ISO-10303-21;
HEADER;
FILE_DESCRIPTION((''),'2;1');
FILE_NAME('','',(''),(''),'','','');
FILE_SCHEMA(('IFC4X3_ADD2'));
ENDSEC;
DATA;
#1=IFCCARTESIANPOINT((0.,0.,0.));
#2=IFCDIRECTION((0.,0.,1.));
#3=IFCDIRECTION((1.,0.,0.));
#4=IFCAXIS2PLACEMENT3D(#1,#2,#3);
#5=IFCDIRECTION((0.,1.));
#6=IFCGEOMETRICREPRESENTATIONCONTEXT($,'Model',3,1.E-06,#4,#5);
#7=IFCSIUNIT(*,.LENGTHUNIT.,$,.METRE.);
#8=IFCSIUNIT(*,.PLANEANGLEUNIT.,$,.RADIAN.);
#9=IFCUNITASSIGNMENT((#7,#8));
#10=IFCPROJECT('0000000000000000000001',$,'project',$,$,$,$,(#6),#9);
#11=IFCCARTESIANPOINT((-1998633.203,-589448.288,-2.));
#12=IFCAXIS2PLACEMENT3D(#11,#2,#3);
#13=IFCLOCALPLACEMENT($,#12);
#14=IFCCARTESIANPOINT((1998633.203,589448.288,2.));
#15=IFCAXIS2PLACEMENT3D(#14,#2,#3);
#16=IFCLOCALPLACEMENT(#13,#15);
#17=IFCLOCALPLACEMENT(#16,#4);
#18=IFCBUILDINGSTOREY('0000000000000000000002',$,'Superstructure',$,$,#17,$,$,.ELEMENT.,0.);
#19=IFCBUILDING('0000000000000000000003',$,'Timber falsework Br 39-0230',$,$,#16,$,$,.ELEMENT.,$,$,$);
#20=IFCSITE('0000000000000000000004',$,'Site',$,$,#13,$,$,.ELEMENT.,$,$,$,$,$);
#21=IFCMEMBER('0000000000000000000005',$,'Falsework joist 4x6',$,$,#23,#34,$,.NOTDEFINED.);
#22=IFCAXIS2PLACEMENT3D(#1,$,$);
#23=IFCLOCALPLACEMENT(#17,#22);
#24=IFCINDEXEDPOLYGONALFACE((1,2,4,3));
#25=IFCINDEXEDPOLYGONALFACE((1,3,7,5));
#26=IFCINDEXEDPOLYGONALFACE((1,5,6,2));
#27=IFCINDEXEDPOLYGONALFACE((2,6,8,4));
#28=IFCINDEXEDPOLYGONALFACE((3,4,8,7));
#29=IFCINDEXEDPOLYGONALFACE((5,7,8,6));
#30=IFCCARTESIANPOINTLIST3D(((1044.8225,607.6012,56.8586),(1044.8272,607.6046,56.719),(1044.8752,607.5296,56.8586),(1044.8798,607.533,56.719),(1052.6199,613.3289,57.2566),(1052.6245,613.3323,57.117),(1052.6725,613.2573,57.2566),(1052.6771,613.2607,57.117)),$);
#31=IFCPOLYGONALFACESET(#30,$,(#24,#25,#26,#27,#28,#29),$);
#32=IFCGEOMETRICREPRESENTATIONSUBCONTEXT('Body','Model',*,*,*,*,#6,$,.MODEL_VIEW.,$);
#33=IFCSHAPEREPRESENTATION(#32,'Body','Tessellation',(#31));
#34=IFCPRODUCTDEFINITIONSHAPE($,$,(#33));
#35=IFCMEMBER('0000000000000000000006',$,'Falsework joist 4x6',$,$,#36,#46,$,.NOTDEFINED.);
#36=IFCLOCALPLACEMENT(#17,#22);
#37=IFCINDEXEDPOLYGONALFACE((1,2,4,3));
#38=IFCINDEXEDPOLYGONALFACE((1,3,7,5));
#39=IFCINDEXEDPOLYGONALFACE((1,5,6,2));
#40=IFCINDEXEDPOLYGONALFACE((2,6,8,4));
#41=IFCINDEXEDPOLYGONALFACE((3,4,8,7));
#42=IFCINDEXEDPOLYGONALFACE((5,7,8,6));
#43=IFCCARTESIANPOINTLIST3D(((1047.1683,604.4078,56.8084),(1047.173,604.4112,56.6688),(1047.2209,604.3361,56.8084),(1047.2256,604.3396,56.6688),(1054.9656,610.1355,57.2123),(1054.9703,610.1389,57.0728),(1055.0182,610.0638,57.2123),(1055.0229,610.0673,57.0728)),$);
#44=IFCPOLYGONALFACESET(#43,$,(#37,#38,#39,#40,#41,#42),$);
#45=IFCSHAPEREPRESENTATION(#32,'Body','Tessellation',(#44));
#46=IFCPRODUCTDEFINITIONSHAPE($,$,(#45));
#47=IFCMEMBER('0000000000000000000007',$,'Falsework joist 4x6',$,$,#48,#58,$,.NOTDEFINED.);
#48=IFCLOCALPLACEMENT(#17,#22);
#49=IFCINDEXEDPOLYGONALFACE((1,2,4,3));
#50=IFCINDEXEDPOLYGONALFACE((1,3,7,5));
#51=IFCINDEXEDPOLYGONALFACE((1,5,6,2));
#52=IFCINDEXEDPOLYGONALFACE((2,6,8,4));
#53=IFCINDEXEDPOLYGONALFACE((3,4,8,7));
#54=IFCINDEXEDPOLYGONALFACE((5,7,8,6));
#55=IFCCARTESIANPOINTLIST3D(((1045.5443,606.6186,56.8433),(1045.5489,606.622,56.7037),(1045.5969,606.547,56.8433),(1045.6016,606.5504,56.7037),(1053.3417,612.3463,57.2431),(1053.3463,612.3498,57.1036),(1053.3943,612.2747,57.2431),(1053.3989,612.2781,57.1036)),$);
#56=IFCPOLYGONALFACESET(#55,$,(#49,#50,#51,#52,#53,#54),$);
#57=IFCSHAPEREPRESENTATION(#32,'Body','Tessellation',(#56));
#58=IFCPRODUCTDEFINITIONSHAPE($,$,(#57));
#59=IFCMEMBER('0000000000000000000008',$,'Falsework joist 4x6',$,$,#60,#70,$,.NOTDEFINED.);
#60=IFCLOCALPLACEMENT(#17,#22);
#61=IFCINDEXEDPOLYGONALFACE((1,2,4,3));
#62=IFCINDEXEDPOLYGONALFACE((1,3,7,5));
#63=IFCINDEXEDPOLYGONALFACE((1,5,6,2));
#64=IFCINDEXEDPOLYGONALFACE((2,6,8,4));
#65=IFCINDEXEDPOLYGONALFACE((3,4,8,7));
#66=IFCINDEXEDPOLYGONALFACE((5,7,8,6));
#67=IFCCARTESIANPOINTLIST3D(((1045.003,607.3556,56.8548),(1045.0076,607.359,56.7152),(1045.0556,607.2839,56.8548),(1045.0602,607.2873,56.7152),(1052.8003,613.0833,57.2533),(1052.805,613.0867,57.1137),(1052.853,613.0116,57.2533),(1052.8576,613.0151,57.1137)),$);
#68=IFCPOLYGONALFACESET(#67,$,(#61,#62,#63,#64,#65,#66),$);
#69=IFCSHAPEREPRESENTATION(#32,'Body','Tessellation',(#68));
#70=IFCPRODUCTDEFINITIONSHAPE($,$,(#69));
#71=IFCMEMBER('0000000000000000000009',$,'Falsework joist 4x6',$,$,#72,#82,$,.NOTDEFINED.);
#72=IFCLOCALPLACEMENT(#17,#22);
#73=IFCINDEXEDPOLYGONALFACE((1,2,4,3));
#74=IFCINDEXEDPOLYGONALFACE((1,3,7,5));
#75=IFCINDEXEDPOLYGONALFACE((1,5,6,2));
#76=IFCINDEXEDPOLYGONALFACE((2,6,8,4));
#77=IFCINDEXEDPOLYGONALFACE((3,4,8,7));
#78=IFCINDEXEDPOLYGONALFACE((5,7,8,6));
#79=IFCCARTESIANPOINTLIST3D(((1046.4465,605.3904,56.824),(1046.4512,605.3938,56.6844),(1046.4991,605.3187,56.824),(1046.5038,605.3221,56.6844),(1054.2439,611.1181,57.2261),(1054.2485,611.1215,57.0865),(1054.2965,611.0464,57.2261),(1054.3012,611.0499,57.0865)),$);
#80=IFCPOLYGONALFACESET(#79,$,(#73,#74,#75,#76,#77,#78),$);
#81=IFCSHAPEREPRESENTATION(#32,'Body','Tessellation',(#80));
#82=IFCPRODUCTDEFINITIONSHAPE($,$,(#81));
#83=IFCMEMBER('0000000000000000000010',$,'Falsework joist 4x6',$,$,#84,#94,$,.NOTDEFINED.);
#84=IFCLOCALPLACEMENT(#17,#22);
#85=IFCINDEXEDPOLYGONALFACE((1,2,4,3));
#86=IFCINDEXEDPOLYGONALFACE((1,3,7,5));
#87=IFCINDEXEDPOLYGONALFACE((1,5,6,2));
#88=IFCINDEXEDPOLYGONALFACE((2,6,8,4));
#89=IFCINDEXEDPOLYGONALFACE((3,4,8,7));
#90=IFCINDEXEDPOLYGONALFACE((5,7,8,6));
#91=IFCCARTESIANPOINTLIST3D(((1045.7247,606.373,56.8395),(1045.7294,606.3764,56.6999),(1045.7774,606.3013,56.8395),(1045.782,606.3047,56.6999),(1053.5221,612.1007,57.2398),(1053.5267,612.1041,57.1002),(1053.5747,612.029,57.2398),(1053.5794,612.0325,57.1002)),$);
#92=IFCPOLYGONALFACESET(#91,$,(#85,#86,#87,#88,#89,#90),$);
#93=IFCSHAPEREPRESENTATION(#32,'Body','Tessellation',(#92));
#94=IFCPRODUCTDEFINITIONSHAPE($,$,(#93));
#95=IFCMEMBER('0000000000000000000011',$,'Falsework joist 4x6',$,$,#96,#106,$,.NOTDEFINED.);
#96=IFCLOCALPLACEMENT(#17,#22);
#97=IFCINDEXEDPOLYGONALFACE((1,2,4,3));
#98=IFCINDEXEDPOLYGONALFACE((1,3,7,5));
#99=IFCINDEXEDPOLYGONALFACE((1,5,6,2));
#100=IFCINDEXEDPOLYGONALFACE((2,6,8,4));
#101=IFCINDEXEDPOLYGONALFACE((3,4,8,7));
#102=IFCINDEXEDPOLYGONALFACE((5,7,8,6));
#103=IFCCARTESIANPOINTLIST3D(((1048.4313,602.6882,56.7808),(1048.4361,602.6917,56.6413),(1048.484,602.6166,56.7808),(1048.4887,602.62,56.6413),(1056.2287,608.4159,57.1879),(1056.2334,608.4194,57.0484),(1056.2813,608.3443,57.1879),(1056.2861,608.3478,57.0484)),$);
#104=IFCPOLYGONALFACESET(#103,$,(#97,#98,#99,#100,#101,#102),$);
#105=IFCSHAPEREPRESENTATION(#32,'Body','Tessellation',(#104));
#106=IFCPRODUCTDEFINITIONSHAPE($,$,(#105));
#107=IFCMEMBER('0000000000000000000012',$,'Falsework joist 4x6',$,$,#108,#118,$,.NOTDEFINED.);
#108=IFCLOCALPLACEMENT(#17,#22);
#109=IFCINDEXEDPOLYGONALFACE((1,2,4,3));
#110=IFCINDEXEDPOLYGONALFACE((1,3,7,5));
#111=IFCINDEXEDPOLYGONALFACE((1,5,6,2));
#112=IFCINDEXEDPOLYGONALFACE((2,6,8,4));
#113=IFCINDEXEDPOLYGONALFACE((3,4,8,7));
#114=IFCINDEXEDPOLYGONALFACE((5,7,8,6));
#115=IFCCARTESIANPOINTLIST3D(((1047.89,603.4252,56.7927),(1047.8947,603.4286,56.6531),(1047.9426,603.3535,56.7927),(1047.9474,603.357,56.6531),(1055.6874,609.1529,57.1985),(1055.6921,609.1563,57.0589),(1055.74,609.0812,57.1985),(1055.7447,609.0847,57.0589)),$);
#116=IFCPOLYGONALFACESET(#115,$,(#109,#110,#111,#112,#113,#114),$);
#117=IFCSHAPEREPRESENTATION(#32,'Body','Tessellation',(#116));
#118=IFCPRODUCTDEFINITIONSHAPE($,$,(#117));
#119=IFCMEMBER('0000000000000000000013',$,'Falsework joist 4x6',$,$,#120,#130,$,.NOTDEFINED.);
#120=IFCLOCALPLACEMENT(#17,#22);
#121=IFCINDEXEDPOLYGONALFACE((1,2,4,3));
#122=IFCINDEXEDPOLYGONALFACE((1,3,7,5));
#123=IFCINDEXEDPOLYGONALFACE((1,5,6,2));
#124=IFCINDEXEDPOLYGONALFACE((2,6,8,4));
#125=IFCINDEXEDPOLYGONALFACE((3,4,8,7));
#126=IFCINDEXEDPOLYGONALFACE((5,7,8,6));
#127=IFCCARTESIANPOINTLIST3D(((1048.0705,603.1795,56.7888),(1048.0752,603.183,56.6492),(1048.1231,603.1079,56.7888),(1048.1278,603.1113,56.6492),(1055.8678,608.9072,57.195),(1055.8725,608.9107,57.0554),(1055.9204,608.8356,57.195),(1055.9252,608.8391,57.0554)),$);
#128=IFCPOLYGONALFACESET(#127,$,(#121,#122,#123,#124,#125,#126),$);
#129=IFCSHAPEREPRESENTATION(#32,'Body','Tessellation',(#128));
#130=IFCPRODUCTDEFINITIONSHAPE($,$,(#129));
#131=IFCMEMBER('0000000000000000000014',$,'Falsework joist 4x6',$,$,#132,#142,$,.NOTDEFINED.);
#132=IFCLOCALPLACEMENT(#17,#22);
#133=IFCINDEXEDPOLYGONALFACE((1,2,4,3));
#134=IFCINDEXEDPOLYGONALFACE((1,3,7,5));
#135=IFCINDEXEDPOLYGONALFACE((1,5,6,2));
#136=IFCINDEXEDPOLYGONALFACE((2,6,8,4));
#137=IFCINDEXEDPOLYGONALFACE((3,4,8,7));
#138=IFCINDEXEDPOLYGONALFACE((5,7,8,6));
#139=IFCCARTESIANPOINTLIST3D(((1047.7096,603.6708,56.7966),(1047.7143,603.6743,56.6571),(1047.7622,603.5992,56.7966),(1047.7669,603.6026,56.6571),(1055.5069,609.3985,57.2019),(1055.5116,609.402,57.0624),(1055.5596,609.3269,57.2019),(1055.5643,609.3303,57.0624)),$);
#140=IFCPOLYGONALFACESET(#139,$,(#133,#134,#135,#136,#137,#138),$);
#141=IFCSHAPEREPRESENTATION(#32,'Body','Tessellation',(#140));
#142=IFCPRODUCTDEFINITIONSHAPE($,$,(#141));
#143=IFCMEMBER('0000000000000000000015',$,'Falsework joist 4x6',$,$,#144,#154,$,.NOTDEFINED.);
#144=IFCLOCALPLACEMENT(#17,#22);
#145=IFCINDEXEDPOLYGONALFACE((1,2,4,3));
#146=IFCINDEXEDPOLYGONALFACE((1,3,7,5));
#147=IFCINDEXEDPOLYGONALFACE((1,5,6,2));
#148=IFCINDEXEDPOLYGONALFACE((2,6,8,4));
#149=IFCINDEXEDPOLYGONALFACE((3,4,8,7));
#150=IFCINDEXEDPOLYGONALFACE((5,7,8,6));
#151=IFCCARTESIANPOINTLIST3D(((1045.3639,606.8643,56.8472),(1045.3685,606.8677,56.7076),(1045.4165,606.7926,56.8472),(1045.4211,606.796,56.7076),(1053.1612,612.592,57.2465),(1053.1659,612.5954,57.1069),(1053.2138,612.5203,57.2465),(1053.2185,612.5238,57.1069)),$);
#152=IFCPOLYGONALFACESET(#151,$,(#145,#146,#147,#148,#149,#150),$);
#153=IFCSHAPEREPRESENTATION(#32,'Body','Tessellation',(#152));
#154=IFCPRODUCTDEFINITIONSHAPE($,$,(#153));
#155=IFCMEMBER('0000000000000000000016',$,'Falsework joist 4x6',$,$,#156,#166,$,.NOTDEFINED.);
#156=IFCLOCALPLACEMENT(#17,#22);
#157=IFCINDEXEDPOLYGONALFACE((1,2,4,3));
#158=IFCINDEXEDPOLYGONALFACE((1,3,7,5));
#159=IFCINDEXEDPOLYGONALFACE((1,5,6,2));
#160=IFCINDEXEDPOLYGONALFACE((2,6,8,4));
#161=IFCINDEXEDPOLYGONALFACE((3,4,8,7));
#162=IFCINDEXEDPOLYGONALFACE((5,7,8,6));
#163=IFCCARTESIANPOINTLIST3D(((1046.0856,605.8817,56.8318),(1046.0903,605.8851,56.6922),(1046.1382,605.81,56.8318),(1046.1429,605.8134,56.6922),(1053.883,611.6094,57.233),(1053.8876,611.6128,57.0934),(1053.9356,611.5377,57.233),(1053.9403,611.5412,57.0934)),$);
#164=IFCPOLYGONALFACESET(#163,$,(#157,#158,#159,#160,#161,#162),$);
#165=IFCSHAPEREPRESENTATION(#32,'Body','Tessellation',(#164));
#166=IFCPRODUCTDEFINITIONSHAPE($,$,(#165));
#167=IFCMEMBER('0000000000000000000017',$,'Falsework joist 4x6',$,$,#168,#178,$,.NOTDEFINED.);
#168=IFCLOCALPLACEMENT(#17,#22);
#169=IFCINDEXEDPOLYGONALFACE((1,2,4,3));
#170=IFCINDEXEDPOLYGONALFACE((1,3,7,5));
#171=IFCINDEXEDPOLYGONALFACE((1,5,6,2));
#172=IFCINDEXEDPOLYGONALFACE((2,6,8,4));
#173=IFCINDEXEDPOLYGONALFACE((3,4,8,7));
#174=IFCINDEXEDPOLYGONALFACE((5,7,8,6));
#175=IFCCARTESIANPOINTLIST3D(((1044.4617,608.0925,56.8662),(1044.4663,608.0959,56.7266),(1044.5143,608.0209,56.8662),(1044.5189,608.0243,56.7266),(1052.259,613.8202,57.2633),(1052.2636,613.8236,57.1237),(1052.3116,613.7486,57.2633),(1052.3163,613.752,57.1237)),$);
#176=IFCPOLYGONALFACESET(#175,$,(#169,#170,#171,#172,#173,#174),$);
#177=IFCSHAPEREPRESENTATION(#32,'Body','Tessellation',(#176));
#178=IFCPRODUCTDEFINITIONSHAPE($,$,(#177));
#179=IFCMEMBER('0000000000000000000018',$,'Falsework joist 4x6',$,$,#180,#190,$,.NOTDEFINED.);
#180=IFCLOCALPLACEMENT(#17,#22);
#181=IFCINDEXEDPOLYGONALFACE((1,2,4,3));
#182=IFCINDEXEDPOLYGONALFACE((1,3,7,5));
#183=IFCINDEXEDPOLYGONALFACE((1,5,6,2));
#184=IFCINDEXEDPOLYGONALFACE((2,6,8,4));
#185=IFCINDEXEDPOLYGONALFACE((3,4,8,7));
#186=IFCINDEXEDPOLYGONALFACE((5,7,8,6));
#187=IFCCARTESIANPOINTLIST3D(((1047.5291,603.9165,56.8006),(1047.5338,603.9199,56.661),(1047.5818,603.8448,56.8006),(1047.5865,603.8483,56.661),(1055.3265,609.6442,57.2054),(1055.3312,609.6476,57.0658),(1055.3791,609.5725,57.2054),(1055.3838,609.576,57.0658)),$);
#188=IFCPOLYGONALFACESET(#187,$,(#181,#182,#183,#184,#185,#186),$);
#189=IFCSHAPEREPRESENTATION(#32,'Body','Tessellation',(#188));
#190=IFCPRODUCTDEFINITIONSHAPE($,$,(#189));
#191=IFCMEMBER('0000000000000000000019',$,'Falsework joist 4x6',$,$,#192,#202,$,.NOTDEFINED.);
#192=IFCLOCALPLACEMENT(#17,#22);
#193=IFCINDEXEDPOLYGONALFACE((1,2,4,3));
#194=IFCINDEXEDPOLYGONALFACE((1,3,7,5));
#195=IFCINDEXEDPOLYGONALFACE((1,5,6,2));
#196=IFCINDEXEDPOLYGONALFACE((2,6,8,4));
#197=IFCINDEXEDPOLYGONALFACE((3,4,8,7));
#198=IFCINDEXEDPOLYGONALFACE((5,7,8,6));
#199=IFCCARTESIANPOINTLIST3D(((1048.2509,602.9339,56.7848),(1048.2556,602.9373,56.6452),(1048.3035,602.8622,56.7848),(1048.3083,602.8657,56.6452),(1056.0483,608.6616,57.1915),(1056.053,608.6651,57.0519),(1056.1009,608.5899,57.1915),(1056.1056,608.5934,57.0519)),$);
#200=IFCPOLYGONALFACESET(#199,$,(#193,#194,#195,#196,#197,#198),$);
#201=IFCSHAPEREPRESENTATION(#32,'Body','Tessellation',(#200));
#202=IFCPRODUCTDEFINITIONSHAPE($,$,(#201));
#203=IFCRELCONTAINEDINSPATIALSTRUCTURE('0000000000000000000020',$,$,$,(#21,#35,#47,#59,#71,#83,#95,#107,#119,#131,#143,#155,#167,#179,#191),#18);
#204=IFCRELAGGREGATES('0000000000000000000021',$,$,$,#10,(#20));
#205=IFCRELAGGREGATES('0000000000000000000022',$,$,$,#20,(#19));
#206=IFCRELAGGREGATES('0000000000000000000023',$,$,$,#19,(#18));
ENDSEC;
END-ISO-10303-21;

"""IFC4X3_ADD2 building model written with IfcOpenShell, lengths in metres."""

from ifc_helpers import new_model, si_unit, direction, frame, frame_2d, origin, origin_with_axes, place, context, subcontext, project, spatial, rectangle, extrude, element, save


model = new_model("IFC4X3_ADD2")

# Units and contexts
model_context = context("Model", 3, precision=1e-06, world=origin_with_axes(), true_north=direction((0.0, 1.0)))
body_context = subcontext(model_context, "Body", "Model", "MODEL_VIEW")
ifc_project = project(units=[si_unit("LENGTHUNIT", "METRE"), si_unit("PLANEANGLEUNIT", "RADIAN")], contexts=[model_context])

# Site, building, storey
site_placement = place(None, frame((-1998633.203, -589448.288, -2.0), z_axis=(0.0, 0.0, 1.0), x_axis=(1.0, 0.0, 0.0)))
site = spatial("IfcSite", under=ifc_project, at=site_placement, Name="Site", CompositionType="ELEMENT")
building_placement = place(site_placement, frame((1998633.203, 589448.288, 2.0), z_axis=(0.0, 0.0, 1.0), x_axis=(1.0, 0.0, 0.0)))
building = spatial("IfcBuilding", under=site, at=building_placement, Name="Timber falsework Br 39-0230", CompositionType="ELEMENT")
storey_placement = place(building_placement, origin_with_axes())
storey = spatial("IfcBuildingStorey", under=building, at=storey_placement, Name="Superstructure", CompositionType="ELEMENT", Elevation=0.0)

# Members
member_1_placement = place(storey_placement, frame((1044.8535, 607.5688, 56.719), z_axis=(0.805247, 0.591513, 0.041103), x_axis=(-0.592013, 0.805928, 0.0)))
element("IfcMember", 1, at=member_1_placement, inside=storey, Name="Falsework joist 4x6", PredefinedType="NOTDEFINED", context=body_context, shape_type="SweptSolid", body=[
    extrude(rectangle(XDim=0.0889, YDim=0.1397, at=frame_2d((0.0, 0.0698))), origin(), (0.0, 0.0, 1.0), 9.6832),
])
member_2_placement = place(storey_placement, frame((1047.1993, 604.3754, 56.6688), z_axis=(0.805227, 0.591498, 0.041713), x_axis=(-0.592013, 0.805928, 0.0)))
element("IfcMember", 2, at=member_2_placement, inside=storey, Name="Falsework joist 4x6", PredefinedType="NOTDEFINED", context=body_context, shape_type="SweptSolid", body=[
    extrude(rectangle(XDim=0.0889, YDim=0.1397, at=frame_2d((0.0, 0.0698))), origin(), (0.0, 0.0, 1.0), 9.6834),
])
member_3_placement = place(storey_placement, frame((1045.5753, 606.5862, 56.7037), z_axis=(0.805241, 0.591508, 0.041291), x_axis=(-0.592013, 0.805928, 0.0)))
element("IfcMember", 3, at=member_3_placement, inside=storey, Name="Falsework joist 4x6", PredefinedType="NOTDEFINED", context=body_context, shape_type="SweptSolid", body=[
    extrude(rectangle(XDim=0.0889, YDim=0.1397, at=frame_2d((0.0, 0.0698))), origin(), (0.0, 0.0, 1.0), 9.6833),
])
member_4_placement = place(storey_placement, frame((1045.0339, 607.3231, 56.7152), z_axis=(0.805246, 0.591512, 0.04115), x_axis=(-0.592013, 0.805928, 0.0)))
element("IfcMember", 4, at=member_4_placement, inside=storey, Name="Falsework joist 4x6", PredefinedType="NOTDEFINED", context=body_context, shape_type="SweptSolid", body=[
    extrude(rectangle(XDim=0.0889, YDim=0.1397, at=frame_2d((0.0, 0.0698))), origin(), (0.0, 0.0, 1.0), 9.6832),
])
member_5_placement = place(storey_placement, frame((1046.4775, 605.358, 56.6844), z_axis=(0.805233, 0.591503, 0.041525), x_axis=(-0.592013, 0.805928, 0.0)))
element("IfcMember", 5, at=member_5_placement, inside=storey, Name="Falsework joist 4x6", PredefinedType="NOTDEFINED", context=body_context, shape_type="SweptSolid", body=[
    extrude(rectangle(XDim=0.0889, YDim=0.1397, at=frame_2d((0.0, 0.0698))), origin(), (0.0, 0.0, 1.0), 9.6834),
])
member_6_placement = place(storey_placement, frame((1045.7557, 606.3406, 56.6999), z_axis=(0.805239, 0.591507, 0.041338), x_axis=(-0.592013, 0.805928, 0.0)))
element("IfcMember", 6, at=member_6_placement, inside=storey, Name="Falsework joist 4x6", PredefinedType="NOTDEFINED", context=body_context, shape_type="SweptSolid", body=[
    extrude(rectangle(XDim=0.0889, YDim=0.1397, at=frame_2d((0.0, 0.0698))), origin(), (0.0, 0.0, 1.0), 9.6833),
])
member_7_placement = place(storey_placement, frame((1048.4624, 602.6559, 56.6413), z_axis=(0.805216, 0.59149, 0.042041), x_axis=(-0.592013, 0.805928, 0.0)))
element("IfcMember", 7, at=member_7_placement, inside=storey, Name="Falsework joist 4x6", PredefinedType="NOTDEFINED", context=body_context, shape_type="SweptSolid", body=[
    extrude(rectangle(XDim=0.0889, YDim=0.1397, at=frame_2d((0.0, 0.0698))), origin(), (0.0, 0.0, 1.0), 9.6836),
])
member_8_placement = place(storey_placement, frame((1047.9211, 603.3928, 56.6531), z_axis=(0.805221, 0.591493, 0.041901), x_axis=(-0.592013, 0.805928, 0.0)))
element("IfcMember", 8, at=member_8_placement, inside=storey, Name="Falsework joist 4x6", PredefinedType="NOTDEFINED", context=body_context, shape_type="SweptSolid", body=[
    extrude(rectangle(XDim=0.0889, YDim=0.1397, at=frame_2d((0.0, 0.0698))), origin(), (0.0, 0.0, 1.0), 9.6835),
])
member_9_placement = place(storey_placement, frame((1048.1015, 603.1471, 56.6492), z_axis=(0.805219, 0.591492, 0.041947), x_axis=(-0.592013, 0.805928, 0.0)))
element("IfcMember", 9, at=member_9_placement, inside=storey, Name="Falsework joist 4x6", PredefinedType="NOTDEFINED", context=body_context, shape_type="SweptSolid", body=[
    extrude(rectangle(XDim=0.0889, YDim=0.1397, at=frame_2d((0.0, 0.0698))), origin(), (0.0, 0.0, 1.0), 9.6835),
])
member_10_placement = place(storey_placement, frame((1047.7406, 603.6384, 56.6571), z_axis=(0.805222, 0.591494, 0.041854), x_axis=(-0.592013, 0.805928, 0.0)))
element("IfcMember", 10, at=member_10_placement, inside=storey, Name="Falsework joist 4x6", PredefinedType="NOTDEFINED", context=body_context, shape_type="SweptSolid", body=[
    extrude(rectangle(XDim=0.0889, YDim=0.1397, at=frame_2d((0.0, 0.0698))), origin(), (0.0, 0.0, 1.0), 9.6835),
])
member_11_placement = place(storey_placement, frame((1045.3948, 606.8319, 56.7076), z_axis=(0.805243, 0.591509, 0.041244), x_axis=(-0.592013, 0.805928, 0.0)))
element("IfcMember", 11, at=member_11_placement, inside=storey, Name="Falsework joist 4x6", PredefinedType="NOTDEFINED", context=body_context, shape_type="SweptSolid", body=[
    extrude(rectangle(XDim=0.0889, YDim=0.1397, at=frame_2d((0.0, 0.0698))), origin(), (0.0, 0.0, 1.0), 9.6832),
])
member_12_placement = place(storey_placement, frame((1046.1166, 605.8493, 56.6922), z_axis=(0.805236, 0.591505, 0.041432), x_axis=(-0.592013, 0.805928, 0.0)))
element("IfcMember", 12, at=member_12_placement, inside=storey, Name="Falsework joist 4x6", PredefinedType="NOTDEFINED", context=body_context, shape_type="SweptSolid", body=[
    extrude(rectangle(XDim=0.0889, YDim=0.1397, at=frame_2d((0.0, 0.0698))), origin(), (0.0, 0.0, 1.0), 9.6833),
])
member_13_placement = place(storey_placement, frame((1044.4926, 608.0601, 56.7266), z_axis=(0.80525, 0.591515, 0.04101), x_axis=(-0.592013, 0.805928, 0.0)))
element("IfcMember", 13, at=member_13_placement, inside=storey, Name="Falsework joist 4x6", PredefinedType="NOTDEFINED", context=body_context, shape_type="SweptSolid", body=[
    extrude(rectangle(XDim=0.0889, YDim=0.1397, at=frame_2d((0.0, 0.0698))), origin(), (0.0, 0.0, 1.0), 9.6831),
])
member_14_placement = place(storey_placement, frame((1047.5602, 603.8841, 56.661), z_axis=(0.805224, 0.591496, 0.041807), x_axis=(-0.592013, 0.805928, 0.0)))
element("IfcMember", 14, at=member_14_placement, inside=storey, Name="Falsework joist 4x6", PredefinedType="NOTDEFINED", context=body_context, shape_type="SweptSolid", body=[
    extrude(rectangle(XDim=0.0889, YDim=0.1397, at=frame_2d((0.0, 0.0698))), origin(), (0.0, 0.0, 1.0), 9.6835),
])
member_15_placement = place(storey_placement, frame((1048.2819, 602.9015, 56.6452), z_axis=(0.805217, 0.591491, 0.041994), x_axis=(-0.592013, 0.805928, 0.0)))
element("IfcMember", 15, at=member_15_placement, inside=storey, Name="Falsework joist 4x6", PredefinedType="NOTDEFINED", context=body_context, shape_type="SweptSolid", body=[
    extrude(rectangle(XDim=0.0889, YDim=0.1397, at=frame_2d((0.0, 0.0698))), origin(), (0.0, 0.0, 1.0), 9.6835),
])

save(model, "model.ifc")
